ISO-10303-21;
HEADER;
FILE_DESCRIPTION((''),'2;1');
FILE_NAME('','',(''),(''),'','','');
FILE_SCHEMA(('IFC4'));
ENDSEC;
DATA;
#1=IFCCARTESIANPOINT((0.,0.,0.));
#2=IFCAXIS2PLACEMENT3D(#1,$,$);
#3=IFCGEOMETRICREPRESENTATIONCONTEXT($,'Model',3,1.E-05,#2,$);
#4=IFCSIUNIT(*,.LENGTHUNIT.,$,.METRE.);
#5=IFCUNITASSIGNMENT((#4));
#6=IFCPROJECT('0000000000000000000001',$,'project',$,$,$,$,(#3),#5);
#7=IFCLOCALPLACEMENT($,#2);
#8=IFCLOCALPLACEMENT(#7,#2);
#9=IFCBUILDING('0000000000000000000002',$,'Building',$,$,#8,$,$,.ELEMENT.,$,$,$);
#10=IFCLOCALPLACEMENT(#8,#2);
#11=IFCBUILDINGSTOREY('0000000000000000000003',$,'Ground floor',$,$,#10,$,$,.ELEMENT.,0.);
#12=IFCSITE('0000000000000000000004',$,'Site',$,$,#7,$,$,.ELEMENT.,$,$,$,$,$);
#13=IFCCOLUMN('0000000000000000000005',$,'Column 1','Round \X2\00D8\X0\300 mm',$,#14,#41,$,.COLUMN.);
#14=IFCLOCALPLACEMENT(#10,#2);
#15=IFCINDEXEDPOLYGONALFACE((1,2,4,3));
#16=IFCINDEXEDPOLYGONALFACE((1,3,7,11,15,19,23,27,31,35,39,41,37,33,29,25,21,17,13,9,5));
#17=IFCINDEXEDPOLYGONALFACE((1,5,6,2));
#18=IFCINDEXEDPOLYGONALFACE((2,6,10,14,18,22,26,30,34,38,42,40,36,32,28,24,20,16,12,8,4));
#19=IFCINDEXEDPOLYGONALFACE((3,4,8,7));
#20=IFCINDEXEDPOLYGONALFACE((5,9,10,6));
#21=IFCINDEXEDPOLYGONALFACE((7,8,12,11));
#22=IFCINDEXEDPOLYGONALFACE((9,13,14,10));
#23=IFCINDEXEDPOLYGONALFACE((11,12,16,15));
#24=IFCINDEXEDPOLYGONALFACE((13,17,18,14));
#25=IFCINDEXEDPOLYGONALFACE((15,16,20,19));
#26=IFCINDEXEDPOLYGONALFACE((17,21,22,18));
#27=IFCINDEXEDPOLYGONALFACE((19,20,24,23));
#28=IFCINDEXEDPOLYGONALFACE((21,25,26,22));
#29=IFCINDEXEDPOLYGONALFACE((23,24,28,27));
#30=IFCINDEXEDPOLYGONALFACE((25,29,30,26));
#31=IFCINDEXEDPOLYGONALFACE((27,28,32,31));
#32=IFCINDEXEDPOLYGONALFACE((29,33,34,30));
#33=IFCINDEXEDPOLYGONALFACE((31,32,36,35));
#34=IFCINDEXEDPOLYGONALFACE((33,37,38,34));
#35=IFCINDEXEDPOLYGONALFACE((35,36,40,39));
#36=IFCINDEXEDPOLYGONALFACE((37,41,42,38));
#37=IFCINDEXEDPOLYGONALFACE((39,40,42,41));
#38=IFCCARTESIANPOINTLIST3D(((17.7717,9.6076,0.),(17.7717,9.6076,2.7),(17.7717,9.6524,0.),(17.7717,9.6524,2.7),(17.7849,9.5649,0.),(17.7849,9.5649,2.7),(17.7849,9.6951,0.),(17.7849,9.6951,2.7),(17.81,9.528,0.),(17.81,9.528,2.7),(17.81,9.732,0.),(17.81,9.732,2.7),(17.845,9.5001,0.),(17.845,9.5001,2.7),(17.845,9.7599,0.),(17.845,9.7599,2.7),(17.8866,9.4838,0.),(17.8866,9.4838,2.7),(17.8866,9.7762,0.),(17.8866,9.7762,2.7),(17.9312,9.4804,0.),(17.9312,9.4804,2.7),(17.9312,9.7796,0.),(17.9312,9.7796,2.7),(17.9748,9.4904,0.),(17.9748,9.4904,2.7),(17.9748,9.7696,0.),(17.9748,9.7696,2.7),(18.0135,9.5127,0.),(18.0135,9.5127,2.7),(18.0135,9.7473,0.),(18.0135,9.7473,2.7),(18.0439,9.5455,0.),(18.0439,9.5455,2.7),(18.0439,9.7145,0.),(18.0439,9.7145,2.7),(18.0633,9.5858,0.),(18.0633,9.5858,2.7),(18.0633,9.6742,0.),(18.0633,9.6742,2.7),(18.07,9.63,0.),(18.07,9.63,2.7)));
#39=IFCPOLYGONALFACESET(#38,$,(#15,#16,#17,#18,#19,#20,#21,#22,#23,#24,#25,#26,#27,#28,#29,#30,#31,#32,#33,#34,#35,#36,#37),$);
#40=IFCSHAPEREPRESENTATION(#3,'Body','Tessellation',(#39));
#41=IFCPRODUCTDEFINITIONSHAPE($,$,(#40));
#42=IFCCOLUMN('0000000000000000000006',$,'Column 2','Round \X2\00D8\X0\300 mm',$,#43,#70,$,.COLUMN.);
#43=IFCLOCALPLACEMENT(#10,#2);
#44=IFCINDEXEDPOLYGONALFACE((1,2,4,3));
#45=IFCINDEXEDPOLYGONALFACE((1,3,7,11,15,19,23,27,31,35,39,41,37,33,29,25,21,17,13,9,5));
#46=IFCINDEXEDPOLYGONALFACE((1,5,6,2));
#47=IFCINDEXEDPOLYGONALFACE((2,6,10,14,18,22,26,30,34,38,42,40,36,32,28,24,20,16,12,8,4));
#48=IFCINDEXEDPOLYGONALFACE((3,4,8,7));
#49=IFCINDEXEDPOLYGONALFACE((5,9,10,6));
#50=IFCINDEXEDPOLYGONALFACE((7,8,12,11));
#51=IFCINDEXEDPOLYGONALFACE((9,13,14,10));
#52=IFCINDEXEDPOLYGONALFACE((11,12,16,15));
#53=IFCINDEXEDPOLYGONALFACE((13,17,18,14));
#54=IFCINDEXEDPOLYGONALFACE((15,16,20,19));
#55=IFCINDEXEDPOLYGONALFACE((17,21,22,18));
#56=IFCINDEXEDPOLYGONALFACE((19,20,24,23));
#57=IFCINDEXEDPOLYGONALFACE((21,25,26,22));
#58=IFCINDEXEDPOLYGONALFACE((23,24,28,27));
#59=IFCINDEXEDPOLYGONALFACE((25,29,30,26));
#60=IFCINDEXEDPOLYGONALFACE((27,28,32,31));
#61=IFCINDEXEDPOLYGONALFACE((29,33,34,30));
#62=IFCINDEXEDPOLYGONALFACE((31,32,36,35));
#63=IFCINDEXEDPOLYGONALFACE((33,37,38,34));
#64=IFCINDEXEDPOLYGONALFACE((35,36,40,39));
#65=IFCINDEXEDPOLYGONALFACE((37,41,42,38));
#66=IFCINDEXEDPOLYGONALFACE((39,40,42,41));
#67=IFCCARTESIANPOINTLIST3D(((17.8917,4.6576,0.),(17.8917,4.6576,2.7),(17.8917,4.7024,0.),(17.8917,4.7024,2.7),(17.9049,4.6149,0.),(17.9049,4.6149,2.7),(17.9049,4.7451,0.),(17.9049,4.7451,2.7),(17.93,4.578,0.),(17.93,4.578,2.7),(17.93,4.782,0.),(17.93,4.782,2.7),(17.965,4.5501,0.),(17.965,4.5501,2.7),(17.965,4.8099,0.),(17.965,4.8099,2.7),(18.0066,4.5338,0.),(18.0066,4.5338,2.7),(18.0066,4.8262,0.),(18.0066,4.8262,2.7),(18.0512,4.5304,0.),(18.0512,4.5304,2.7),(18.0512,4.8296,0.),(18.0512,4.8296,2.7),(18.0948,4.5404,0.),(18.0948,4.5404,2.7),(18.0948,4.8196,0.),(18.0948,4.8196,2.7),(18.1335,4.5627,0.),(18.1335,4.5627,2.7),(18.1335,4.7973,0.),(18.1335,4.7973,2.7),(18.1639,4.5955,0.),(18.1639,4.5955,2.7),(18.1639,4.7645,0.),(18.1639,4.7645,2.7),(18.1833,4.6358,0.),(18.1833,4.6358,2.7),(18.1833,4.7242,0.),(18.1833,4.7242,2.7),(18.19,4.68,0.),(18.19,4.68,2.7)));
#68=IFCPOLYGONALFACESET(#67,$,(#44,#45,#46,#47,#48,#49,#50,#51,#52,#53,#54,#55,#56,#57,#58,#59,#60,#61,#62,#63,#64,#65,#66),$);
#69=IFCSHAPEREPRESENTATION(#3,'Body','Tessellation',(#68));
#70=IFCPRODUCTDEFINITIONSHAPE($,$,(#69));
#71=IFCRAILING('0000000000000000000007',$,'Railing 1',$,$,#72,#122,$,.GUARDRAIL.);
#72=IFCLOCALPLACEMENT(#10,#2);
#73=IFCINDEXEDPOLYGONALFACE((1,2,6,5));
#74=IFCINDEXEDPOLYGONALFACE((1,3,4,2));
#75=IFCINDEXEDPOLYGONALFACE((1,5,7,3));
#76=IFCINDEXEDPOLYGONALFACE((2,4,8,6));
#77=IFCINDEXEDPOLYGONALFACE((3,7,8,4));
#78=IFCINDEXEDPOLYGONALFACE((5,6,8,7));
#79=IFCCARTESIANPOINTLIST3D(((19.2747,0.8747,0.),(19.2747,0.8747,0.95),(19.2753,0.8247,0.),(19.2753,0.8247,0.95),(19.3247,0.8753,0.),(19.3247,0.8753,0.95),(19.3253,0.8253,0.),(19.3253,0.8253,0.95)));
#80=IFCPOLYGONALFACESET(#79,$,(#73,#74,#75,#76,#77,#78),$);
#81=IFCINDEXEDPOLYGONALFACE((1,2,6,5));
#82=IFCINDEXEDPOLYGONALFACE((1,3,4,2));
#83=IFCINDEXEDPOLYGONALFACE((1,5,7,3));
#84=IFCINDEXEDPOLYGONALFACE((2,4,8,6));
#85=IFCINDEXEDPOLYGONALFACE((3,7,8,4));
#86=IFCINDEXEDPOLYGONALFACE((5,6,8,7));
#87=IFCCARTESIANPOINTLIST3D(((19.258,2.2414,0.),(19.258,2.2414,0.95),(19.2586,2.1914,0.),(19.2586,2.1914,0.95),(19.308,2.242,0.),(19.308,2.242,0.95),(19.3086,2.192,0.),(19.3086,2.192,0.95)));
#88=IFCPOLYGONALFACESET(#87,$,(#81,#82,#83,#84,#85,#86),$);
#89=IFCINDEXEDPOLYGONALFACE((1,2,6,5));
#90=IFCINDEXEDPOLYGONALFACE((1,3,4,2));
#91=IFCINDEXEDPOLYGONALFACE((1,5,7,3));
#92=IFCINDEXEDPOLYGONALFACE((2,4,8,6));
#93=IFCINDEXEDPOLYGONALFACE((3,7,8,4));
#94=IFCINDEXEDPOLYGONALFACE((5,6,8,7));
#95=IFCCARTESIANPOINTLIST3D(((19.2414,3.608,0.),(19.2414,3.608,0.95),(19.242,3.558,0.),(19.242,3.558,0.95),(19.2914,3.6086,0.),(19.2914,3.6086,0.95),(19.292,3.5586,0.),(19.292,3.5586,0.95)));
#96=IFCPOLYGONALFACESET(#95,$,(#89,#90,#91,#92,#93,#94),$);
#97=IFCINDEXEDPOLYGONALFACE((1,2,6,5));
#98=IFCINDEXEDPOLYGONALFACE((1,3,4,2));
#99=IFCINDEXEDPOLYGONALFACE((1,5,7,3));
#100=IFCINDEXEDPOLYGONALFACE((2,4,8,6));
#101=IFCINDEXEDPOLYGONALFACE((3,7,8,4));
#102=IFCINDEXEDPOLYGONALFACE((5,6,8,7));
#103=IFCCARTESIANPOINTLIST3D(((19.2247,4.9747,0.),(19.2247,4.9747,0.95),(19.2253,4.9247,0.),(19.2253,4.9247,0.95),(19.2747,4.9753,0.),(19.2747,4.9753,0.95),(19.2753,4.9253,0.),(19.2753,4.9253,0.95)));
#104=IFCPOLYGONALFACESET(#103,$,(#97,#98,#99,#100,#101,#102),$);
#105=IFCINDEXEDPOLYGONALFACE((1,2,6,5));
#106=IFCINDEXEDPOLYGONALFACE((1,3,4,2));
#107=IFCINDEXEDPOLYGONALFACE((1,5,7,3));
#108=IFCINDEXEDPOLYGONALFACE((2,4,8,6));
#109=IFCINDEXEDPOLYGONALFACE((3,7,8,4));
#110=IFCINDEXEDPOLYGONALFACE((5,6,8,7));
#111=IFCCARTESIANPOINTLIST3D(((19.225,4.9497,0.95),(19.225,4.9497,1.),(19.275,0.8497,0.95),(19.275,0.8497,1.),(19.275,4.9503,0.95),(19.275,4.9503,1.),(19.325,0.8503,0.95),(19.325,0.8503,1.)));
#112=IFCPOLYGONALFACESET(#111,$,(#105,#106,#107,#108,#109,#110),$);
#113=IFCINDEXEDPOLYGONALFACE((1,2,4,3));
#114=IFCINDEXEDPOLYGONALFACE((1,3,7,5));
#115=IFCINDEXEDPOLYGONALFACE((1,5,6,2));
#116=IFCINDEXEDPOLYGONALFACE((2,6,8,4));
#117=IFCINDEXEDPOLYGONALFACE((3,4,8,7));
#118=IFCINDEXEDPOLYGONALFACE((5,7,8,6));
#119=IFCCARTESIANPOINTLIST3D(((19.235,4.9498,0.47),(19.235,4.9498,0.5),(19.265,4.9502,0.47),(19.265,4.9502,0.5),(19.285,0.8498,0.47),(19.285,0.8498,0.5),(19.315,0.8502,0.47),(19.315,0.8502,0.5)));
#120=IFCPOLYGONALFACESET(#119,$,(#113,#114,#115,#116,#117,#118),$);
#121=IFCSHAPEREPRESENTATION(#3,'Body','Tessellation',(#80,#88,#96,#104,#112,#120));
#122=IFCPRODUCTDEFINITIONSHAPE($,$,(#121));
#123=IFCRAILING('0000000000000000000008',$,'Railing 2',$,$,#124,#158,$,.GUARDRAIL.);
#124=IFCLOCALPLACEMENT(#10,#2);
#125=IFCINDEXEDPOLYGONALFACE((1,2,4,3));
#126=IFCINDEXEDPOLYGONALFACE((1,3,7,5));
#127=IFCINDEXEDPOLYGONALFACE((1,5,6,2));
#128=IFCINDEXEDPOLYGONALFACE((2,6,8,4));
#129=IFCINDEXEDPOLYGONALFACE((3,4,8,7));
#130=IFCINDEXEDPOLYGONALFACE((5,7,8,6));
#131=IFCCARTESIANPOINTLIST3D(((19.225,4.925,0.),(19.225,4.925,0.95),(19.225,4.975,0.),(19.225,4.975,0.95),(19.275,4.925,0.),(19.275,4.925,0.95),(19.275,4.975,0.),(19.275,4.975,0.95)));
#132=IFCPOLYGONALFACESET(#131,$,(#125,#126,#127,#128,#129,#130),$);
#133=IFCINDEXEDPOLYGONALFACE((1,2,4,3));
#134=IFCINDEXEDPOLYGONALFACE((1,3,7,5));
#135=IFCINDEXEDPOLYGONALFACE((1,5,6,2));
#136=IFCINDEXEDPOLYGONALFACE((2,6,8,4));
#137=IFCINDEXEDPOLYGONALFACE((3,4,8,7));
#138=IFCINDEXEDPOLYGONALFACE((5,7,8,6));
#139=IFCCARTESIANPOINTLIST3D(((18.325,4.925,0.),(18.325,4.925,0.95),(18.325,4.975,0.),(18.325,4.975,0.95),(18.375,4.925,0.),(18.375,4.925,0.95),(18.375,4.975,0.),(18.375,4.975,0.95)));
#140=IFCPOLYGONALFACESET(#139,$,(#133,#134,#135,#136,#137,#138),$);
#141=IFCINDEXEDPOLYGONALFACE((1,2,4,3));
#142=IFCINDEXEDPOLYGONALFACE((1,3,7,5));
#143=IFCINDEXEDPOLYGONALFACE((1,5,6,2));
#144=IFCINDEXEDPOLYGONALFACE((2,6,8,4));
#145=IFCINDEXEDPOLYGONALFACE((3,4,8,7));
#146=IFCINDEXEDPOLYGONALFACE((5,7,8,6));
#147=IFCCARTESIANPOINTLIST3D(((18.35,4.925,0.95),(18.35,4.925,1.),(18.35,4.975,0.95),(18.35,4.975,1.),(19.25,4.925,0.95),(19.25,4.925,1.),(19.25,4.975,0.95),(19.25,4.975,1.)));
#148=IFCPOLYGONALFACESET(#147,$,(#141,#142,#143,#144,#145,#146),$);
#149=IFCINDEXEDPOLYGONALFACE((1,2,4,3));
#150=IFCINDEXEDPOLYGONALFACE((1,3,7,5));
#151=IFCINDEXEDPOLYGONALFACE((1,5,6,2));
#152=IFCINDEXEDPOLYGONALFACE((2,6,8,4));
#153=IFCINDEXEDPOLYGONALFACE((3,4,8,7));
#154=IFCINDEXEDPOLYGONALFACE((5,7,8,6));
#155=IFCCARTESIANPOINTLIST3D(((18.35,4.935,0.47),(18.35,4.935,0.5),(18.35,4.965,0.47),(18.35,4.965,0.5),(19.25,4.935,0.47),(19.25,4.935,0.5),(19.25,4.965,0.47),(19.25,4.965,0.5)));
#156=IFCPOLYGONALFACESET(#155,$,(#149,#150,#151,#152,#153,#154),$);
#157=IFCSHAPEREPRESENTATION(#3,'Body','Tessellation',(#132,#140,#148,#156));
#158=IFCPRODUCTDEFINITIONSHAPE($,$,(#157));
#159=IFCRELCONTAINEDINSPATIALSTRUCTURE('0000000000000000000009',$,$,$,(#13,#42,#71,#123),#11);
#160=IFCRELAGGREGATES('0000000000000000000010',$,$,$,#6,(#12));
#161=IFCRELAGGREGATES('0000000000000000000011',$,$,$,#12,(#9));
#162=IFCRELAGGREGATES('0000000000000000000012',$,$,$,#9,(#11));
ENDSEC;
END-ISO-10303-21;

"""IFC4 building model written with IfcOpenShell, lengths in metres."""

from ifc_helpers import new_model, si_unit, frame, frame_2d, origin, origin_2d, place, context, project, spatial, polyline, rectangle, circle, outline, extrude, element, save


model = new_model("IFC4")

# Units and contexts
model_context = context("Model", 3, precision=1e-05, world=origin())
ifc_project = project(units=[si_unit("LENGTHUNIT", "METRE")], contexts=[model_context])

# Site, building, storey
site_placement = place(None, origin())
site = spatial("IfcSite", under=ifc_project, at=site_placement, Name="Site", CompositionType="ELEMENT")
building_placement = place(site_placement, origin())
building = spatial("IfcBuilding", under=site, at=building_placement, Name="Building", CompositionType="ELEMENT")
storey_placement = place(building_placement, origin())
storey = spatial("IfcBuildingStorey", under=building, at=storey_placement, Name="Ground floor", CompositionType="ELEMENT", Elevation=0.0)

# Columns
for number, where, z_axis, x_axis, name in (
    (1, (17.92, 9.63, 0.0), (0.0, 0.0, 1.0), (1.0, 0.0, 0.0), "Column 1"),
    (2, (18.04, 4.68, 0.0), (0.0, 0.0, 1.0), (1.0, 0.0, 0.0), "Column 2"),
):
    element("IfcColumn", number, at=place(storey_placement, frame(where, z_axis=z_axis, x_axis=x_axis)), inside=storey, Name=name, Description="Round Ø300 mm", PredefinedType="COLUMN", context=model_context, shape_type="SweptSolid", body=[
        extrude(circle(Radius=0.15, at=origin_2d()), origin(), (0.0, 0.0, 1.0), 2.7),
    ])

# Railings
railing_1_placement = place(storey_placement, frame((19.3, 0.85, 0.0), z_axis=(0.0, 0.0, 1.0), x_axis=(-0.012194, 0.999926, 0.0)))
element("IfcRailing", 3, at=railing_1_placement, inside=storey, Name="Railing 1", PredefinedType="GUARDRAIL", context=model_context, shape_type="SweptSolid", body=[
    extrude(rectangle(XDim=0.05, YDim=0.05, at=origin_2d()), origin(), (0.0, 0.0, 1.0), 0.95),
    extrude(rectangle(XDim=0.05, YDim=0.05, at=frame_2d((1.3668, 0.0))), origin(), (0.0, 0.0, 1.0), 0.95),
    extrude(rectangle(XDim=0.05, YDim=0.05, at=frame_2d((2.7335, 0.0))), origin(), (0.0, 0.0, 1.0), 0.95),
    extrude(rectangle(XDim=0.05, YDim=0.05, at=frame_2d((4.1003, 0.0))), origin(), (0.0, 0.0, 1.0), 0.95),
    extrude(outline(polyline([(0.0, 0.95), (4.1003, 0.95), (4.1003, 1.0), (0.0, 1.0), (0.0, 0.95)])), frame((0.0, 0.025, 0.0), z_axis=(0.0, -1.0, 0.0), x_axis=(1.0, 0.0, 0.0)), (0.0, 0.0, 1.0), 0.05),
    extrude(outline(polyline([(0.0, 0.47), (4.1003, 0.47), (4.1003, 0.5), (0.0, 0.5), (0.0, 0.47)])), frame((0.0, 0.015, 0.0), z_axis=(0.0, -1.0, 0.0), x_axis=(1.0, 0.0, 0.0)), (0.0, 0.0, 1.0), 0.03),
])
railing_2_placement = place(storey_placement, frame((19.25, 4.95, 0.0), z_axis=(0.0, 0.0, 1.0), x_axis=(-1.0, 0.0, 0.0)))
element("IfcRailing", 4, at=railing_2_placement, inside=storey, Name="Railing 2", PredefinedType="GUARDRAIL", context=model_context, shape_type="SweptSolid", body=[
    extrude(rectangle(XDim=0.05, YDim=0.05, at=origin_2d()), origin(), (0.0, 0.0, 1.0), 0.95),
    extrude(rectangle(XDim=0.05, YDim=0.05, at=frame_2d((0.9, 0.0))), origin(), (0.0, 0.0, 1.0), 0.95),
    extrude(outline(polyline([(0.0, 0.95), (0.9, 0.95), (0.9, 1.0), (0.0, 1.0), (0.0, 0.95)])), frame((0.0, 0.025, 0.0), z_axis=(0.0, -1.0, 0.0), x_axis=(1.0, 0.0, 0.0)), (0.0, 0.0, 1.0), 0.05),
    extrude(outline(polyline([(0.0, 0.47), (0.9, 0.47), (0.9, 0.5), (0.0, 0.5), (0.0, 0.47)])), frame((0.0, 0.015, 0.0), z_axis=(0.0, -1.0, 0.0), x_axis=(1.0, 0.0, 0.0)), (0.0, 0.0, 1.0), 0.03),
])

save(model, "model.ifc")
